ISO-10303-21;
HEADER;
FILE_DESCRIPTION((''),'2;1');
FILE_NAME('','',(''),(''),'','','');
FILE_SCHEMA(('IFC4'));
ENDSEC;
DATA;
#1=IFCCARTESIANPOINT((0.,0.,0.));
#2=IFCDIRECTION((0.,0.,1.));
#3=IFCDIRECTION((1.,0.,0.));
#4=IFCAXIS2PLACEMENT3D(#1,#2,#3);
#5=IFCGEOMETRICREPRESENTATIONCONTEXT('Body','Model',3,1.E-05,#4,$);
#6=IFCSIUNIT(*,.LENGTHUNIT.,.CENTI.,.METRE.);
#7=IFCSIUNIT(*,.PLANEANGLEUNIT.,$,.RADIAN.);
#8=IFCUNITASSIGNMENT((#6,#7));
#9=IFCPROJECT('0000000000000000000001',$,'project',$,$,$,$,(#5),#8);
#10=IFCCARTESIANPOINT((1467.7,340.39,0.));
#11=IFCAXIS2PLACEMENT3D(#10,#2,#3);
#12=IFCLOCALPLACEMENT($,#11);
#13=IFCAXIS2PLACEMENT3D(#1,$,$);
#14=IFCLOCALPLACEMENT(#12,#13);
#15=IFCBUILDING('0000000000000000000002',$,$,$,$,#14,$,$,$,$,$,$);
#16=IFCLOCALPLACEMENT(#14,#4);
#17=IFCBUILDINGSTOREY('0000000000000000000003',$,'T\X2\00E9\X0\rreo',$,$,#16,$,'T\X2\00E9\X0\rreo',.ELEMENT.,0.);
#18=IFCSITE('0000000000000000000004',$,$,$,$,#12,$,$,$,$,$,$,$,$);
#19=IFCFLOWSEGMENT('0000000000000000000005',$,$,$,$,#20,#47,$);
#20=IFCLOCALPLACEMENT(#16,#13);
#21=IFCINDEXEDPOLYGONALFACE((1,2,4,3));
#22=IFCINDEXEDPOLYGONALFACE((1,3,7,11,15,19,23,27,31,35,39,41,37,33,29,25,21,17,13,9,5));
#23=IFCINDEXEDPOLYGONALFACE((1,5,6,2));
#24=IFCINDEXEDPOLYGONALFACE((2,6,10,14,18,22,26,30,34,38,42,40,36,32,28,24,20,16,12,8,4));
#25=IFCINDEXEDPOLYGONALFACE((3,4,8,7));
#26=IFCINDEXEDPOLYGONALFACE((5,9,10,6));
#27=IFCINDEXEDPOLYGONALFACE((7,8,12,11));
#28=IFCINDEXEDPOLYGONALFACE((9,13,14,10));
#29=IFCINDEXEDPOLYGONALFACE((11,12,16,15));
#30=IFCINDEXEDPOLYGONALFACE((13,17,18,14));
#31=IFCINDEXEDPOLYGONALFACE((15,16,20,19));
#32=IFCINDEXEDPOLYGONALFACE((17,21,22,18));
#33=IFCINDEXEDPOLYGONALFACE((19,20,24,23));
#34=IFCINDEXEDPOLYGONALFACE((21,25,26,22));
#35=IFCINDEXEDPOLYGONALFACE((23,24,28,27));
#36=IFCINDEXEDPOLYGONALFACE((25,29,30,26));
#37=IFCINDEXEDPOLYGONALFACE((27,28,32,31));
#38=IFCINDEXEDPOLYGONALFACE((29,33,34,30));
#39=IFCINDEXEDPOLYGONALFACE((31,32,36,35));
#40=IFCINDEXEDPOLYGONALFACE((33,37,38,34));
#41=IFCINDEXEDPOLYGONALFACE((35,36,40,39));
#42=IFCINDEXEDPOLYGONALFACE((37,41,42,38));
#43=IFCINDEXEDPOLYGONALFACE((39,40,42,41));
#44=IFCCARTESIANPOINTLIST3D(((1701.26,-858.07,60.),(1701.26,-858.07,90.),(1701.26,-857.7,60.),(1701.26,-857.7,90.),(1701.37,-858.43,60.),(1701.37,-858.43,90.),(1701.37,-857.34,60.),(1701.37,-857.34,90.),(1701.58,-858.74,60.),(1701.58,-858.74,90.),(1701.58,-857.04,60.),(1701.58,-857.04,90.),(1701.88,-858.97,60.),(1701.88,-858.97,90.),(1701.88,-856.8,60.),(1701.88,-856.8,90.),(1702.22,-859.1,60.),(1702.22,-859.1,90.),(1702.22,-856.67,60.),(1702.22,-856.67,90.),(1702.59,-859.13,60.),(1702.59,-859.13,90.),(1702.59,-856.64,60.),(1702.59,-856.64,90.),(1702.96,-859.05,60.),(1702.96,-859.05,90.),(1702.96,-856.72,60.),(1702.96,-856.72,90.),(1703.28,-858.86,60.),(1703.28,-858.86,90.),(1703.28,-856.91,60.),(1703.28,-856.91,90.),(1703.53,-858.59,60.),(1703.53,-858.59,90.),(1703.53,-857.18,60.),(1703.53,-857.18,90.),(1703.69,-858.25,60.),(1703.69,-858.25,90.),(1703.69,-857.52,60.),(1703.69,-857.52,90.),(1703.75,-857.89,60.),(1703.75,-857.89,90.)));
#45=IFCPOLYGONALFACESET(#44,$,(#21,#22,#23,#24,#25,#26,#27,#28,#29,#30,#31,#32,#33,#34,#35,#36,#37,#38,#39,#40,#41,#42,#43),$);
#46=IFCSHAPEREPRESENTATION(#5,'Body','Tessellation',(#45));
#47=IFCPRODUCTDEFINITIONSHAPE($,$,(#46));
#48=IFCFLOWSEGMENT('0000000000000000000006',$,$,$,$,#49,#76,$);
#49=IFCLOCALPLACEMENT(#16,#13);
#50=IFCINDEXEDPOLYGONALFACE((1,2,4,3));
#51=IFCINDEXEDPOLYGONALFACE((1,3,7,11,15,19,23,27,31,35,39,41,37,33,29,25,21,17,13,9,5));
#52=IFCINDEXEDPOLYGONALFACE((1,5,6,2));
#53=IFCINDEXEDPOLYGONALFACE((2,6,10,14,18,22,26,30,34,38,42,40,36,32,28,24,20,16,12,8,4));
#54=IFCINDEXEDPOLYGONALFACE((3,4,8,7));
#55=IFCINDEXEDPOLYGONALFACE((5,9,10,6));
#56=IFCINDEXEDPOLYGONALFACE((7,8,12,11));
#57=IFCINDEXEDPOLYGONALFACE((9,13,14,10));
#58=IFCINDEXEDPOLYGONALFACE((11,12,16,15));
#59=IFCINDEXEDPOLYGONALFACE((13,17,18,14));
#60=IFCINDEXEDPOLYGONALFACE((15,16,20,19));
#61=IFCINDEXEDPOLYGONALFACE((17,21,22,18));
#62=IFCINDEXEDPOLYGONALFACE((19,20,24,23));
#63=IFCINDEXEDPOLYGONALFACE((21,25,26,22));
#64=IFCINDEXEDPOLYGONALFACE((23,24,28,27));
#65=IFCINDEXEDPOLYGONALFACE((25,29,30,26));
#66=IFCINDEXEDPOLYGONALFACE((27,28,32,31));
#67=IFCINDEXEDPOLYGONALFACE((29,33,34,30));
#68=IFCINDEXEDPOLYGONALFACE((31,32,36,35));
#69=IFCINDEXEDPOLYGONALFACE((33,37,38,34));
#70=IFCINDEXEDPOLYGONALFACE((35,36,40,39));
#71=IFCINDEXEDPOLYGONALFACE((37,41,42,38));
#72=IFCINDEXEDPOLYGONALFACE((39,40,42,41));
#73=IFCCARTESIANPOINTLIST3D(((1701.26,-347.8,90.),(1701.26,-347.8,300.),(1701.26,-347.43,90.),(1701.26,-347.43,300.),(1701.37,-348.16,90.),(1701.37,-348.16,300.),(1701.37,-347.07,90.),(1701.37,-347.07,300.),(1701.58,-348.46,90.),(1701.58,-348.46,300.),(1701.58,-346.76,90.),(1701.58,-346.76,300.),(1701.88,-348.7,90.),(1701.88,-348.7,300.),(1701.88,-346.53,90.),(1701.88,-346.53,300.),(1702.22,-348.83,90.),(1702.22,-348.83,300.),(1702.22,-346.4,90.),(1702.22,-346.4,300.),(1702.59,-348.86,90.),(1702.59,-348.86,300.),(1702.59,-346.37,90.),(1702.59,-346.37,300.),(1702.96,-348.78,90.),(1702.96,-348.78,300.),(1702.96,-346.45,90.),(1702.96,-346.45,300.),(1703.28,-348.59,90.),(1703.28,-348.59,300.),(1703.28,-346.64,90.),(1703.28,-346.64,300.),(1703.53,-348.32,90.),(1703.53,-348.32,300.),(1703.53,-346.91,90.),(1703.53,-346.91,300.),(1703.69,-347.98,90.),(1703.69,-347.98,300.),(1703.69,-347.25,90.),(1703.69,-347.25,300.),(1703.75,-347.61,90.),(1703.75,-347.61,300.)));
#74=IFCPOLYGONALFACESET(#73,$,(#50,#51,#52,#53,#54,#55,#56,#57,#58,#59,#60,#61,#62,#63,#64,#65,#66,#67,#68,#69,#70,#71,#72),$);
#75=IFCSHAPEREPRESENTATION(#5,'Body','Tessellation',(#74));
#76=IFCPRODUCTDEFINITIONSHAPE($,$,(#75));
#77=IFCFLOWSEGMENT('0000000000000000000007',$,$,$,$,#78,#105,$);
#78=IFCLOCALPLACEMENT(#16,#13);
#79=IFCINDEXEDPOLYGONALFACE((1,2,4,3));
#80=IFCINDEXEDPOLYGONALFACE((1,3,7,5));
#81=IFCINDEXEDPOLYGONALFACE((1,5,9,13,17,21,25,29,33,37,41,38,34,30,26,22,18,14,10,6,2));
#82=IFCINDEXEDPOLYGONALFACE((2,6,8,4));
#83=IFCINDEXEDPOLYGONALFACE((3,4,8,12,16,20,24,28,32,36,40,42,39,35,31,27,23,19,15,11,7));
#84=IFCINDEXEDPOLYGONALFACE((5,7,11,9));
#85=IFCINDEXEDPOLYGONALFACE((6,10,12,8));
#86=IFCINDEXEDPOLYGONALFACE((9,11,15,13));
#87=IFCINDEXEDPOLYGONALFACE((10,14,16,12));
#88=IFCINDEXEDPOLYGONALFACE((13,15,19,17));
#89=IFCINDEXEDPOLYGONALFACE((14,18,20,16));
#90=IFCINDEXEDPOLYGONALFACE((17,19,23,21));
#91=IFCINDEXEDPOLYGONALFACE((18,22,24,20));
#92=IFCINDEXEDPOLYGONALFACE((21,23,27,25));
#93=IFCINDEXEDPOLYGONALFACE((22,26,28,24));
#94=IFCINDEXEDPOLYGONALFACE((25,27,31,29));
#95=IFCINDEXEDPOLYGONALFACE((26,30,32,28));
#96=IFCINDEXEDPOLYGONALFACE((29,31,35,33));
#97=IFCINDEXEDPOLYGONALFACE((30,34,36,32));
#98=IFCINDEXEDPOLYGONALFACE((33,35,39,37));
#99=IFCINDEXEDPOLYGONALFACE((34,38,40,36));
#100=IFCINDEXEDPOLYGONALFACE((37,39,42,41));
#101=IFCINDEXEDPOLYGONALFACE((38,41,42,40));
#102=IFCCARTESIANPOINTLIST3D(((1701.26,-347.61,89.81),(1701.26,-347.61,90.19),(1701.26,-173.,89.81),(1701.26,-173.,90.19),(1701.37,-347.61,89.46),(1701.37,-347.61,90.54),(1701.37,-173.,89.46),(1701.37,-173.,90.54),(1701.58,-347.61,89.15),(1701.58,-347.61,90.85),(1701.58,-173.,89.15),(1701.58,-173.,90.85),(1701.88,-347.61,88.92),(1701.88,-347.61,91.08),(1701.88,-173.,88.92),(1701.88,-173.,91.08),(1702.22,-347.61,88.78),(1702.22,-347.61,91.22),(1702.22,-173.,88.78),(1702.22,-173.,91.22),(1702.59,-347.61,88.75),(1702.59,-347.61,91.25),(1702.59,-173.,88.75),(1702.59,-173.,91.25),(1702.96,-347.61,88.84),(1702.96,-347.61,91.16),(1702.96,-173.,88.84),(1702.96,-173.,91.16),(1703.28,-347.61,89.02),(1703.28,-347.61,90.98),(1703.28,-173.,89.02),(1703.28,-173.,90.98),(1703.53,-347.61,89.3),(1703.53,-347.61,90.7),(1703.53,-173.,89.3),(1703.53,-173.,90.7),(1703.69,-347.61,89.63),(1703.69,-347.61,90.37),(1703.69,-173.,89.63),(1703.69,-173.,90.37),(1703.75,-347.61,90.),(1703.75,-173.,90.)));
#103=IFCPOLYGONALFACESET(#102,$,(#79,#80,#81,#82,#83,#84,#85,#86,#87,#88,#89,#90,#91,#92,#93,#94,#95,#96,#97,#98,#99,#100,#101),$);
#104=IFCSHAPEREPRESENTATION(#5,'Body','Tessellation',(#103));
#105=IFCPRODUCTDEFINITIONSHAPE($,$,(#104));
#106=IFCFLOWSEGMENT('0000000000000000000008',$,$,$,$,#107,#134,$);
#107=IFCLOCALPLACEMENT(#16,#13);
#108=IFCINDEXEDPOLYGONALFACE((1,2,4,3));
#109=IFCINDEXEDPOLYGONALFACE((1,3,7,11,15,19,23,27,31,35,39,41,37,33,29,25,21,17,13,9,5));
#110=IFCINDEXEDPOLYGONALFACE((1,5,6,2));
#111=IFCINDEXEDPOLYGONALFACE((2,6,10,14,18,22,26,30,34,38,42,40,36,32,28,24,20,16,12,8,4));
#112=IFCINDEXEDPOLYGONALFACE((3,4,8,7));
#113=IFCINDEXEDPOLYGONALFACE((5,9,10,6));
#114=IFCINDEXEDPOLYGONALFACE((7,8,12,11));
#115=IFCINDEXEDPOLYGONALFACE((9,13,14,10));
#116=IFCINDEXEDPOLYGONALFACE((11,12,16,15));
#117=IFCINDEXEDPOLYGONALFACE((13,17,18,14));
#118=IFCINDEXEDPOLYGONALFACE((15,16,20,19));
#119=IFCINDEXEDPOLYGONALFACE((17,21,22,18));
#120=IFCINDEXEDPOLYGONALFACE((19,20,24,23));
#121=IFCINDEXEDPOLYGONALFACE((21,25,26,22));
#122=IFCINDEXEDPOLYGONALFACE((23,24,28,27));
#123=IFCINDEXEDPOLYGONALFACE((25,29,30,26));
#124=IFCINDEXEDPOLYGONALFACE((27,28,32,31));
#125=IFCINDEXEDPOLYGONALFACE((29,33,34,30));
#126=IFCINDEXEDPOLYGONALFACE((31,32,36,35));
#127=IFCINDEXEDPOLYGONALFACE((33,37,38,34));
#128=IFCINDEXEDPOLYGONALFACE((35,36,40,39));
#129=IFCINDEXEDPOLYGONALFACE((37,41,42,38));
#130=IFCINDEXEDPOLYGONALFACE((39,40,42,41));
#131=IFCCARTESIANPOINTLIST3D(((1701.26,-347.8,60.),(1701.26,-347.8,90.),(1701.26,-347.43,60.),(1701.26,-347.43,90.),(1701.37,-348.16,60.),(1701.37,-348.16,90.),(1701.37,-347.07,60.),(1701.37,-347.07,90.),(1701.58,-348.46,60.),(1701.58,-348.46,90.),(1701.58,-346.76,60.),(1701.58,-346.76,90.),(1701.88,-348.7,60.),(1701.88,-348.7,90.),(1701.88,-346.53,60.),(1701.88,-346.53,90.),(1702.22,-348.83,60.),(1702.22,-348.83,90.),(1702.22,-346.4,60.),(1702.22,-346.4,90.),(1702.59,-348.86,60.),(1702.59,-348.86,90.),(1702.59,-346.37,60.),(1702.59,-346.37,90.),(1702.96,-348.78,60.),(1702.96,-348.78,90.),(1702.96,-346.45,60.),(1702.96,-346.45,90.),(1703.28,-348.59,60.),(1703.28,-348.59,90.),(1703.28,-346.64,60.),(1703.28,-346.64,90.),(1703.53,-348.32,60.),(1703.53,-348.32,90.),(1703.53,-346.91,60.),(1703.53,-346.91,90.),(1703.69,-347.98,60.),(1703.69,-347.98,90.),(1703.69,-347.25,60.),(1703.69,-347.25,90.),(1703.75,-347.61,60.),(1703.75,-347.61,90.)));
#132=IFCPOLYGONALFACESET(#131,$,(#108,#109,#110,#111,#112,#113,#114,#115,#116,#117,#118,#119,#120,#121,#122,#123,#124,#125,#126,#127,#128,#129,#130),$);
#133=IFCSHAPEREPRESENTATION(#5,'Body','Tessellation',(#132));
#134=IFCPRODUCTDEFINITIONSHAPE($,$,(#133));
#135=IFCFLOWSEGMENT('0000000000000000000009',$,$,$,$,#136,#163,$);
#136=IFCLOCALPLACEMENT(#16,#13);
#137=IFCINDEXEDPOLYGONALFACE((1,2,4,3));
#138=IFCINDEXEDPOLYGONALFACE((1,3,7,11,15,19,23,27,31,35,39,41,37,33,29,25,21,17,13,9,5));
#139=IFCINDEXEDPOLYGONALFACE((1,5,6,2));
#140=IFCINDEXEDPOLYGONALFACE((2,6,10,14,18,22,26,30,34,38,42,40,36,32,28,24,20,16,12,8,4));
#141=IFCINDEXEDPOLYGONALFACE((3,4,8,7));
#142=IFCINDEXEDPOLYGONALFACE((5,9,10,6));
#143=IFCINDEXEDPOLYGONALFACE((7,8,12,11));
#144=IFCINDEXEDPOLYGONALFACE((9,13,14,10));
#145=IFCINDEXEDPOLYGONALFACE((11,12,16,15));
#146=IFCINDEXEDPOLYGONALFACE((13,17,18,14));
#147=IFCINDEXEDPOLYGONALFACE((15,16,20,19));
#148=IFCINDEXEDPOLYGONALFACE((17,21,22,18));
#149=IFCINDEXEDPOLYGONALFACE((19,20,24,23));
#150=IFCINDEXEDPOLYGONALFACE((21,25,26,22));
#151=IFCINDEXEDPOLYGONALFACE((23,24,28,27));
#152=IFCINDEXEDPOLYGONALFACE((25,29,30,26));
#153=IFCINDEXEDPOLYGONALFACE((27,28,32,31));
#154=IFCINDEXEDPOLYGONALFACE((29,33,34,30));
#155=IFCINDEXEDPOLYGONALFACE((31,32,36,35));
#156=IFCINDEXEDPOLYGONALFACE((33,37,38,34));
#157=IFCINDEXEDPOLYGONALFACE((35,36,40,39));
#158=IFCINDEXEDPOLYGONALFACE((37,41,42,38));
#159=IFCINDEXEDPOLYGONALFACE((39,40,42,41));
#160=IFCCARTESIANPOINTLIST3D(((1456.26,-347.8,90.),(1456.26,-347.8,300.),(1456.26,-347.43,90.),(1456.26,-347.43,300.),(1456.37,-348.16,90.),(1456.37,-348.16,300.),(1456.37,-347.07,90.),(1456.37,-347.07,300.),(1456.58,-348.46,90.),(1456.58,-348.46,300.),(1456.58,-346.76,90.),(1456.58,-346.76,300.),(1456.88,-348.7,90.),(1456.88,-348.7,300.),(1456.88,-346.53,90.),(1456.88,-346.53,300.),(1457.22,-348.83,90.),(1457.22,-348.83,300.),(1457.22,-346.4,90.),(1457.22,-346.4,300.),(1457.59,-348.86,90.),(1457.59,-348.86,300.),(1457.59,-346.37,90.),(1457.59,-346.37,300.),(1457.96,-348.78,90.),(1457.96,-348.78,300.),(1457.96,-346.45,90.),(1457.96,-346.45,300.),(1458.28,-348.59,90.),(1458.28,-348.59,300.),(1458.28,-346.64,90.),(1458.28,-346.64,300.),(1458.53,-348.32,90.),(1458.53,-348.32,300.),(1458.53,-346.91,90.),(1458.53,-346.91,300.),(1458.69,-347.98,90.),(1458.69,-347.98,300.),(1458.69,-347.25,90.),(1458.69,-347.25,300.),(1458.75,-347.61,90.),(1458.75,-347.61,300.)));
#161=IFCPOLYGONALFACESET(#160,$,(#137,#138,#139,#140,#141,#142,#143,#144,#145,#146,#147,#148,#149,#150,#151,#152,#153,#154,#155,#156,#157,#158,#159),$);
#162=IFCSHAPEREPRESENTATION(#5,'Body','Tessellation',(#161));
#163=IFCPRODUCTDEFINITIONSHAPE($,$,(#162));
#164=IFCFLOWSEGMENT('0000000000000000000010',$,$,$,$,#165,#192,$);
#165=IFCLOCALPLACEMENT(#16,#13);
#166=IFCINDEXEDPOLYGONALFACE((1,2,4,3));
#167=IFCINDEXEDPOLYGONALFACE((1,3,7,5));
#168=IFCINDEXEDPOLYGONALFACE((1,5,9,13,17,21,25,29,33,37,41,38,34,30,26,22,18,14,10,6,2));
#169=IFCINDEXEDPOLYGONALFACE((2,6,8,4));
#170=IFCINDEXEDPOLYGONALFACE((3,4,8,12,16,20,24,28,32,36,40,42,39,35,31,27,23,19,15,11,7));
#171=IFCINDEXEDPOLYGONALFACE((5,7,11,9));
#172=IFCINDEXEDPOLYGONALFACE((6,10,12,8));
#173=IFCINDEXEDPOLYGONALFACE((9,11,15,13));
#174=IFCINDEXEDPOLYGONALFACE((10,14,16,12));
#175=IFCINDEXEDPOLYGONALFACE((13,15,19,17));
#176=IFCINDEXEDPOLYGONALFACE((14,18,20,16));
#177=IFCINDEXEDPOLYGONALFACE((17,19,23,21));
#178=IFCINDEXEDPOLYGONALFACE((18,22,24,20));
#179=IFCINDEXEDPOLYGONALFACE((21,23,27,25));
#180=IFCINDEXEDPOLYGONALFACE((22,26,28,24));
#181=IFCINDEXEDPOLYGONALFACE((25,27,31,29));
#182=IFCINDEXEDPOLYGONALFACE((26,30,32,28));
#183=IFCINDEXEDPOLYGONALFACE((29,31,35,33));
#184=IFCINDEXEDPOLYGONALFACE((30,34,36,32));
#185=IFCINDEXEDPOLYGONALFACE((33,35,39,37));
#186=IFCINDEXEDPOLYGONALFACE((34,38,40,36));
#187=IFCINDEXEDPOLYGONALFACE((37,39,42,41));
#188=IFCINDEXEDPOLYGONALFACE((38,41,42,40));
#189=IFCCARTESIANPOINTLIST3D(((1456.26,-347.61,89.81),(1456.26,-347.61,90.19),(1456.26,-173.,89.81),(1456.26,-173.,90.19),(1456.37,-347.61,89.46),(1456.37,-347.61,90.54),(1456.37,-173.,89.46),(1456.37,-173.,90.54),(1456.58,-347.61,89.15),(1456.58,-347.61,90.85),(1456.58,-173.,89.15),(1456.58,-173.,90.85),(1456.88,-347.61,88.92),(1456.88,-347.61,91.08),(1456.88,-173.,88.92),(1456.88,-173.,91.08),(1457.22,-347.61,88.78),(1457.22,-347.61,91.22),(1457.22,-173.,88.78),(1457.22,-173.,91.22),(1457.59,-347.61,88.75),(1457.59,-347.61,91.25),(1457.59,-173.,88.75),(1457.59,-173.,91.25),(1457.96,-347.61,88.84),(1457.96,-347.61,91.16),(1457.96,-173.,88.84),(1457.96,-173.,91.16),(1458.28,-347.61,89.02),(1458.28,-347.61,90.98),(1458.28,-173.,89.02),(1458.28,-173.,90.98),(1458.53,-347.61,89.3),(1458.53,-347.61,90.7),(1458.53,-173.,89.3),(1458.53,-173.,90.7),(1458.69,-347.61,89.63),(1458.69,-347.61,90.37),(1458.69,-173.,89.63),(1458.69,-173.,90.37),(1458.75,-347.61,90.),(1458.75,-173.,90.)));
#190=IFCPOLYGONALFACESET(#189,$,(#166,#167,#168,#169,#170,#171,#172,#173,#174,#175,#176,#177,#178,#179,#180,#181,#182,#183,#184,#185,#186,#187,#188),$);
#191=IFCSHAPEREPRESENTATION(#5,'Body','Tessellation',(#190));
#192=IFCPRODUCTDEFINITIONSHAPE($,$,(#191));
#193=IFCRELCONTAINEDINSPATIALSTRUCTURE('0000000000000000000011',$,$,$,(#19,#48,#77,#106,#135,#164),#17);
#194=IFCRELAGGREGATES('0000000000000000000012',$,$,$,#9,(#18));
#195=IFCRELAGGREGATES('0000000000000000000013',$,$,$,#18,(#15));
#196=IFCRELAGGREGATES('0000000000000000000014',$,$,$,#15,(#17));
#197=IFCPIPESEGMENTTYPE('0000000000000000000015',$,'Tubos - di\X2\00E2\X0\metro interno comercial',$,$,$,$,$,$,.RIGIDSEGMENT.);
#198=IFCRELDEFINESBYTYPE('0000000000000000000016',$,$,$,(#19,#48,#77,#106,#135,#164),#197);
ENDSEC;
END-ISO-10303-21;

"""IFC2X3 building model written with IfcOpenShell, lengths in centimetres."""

from ifc_helpers import new_model, si_unit, frame, origin, origin_with_axes, origin_2d_with_axis, place, context, project, spatial, circle, extrude, type_object, element, save


model = new_model("IFC2X3")

# Units and contexts
model_context = context("Model", 3, precision=1e-05, world=origin_with_axes(), identifier="Body")
ifc_project = project(units=[si_unit("LENGTHUNIT", "METRE", prefix="CENTI"), si_unit("PLANEANGLEUNIT", "RADIAN")], contexts=[model_context])

# Site, building, storey
site_placement = place(None, frame((1467.7, 340.39, 0.0), z_axis=(0.0, 0.0, 1.0), x_axis=(1.0, 0.0, 0.0)))
site = spatial("IfcSite", under=ifc_project, at=site_placement)
building_placement = place(site_placement, origin())
building = spatial("IfcBuilding", under=site, at=building_placement)
storey_placement = place(building_placement, origin_with_axes())
storey = spatial("IfcBuildingStorey", under=building, at=storey_placement, Name="Térreo", LongName="Térreo", CompositionType="ELEMENT", Elevation=0.0)

# Flow segments
pipe_segment_type_1 = type_object("IfcPipeSegmentType", Name="Tubos - diâmetro interno comercial", PredefinedType="RIGIDSEGMENT")
flow_segment_1_placement = place(storey_placement, frame((1702.5, -857.89, 90.0), z_axis=(0.0, 0.0, 1.0), x_axis=(1.0, 0.0, 0.0)))
element("IfcFlowSegment", 1, at=flow_segment_1_placement, inside=storey, type_object=pipe_segment_type_1, context=model_context, shape_type="SolidModel", body=[
    extrude(circle(Radius=1.25, at=origin_2d_with_axis()), frame((0.0, 0.0, 0.0), z_axis=(0.0, 0.0, -1.0), x_axis=(1.0, 0.0, 0.0)), (0.0, 0.0, 1.0), 30.0),
])
flow_segment_2_placement = place(storey_placement, frame((1702.5, -347.61, 300.0), z_axis=(0.0, 0.0, 1.0), x_axis=(1.0, 0.0, 0.0)))
element("IfcFlowSegment", 2, at=flow_segment_2_placement, inside=storey, type_object=pipe_segment_type_1, context=model_context, shape_type="SolidModel", body=[
    extrude(circle(Radius=1.25, at=origin_2d_with_axis()), frame((0.0, 0.0, 0.0), z_axis=(0.0, 0.0, -1.0), x_axis=(1.0, 0.0, 0.0)), (0.0, 0.0, 1.0), 210.0),
])
flow_segment_3_placement = place(storey_placement, frame((1702.5, -260.31, 91.25), z_axis=(0.0, 0.0, 1.0), x_axis=(1.0, 0.0, 0.0)))
element("IfcFlowSegment", 3, at=flow_segment_3_placement, inside=storey, type_object=pipe_segment_type_1, context=model_context, shape_type="SolidModel", body=[
    extrude(circle(Radius=1.25, at=origin_2d_with_axis()), frame((0.0, -87.31, -1.25), z_axis=(0.0, 1.0, 0.0), x_axis=(1.0, 0.0, 0.0)), (0.0, 0.0, 1.0), 174.61),
])
flow_segment_4_placement = place(storey_placement, frame((1702.5, -347.61, 90.0), z_axis=(0.0, 0.0, 1.0), x_axis=(1.0, 0.0, 0.0)))
element("IfcFlowSegment", 4, at=flow_segment_4_placement, inside=storey, type_object=pipe_segment_type_1, context=model_context, shape_type="SolidModel", body=[
    extrude(circle(Radius=1.25, at=origin_2d_with_axis()), frame((0.0, 0.0, 0.0), z_axis=(0.0, 0.0, -1.0), x_axis=(1.0, 0.0, 0.0)), (0.0, 0.0, 1.0), 30.0),
])
flow_segment_5_placement = place(storey_placement, frame((1457.5, -347.61, 300.0), z_axis=(0.0, 0.0, 1.0), x_axis=(1.0, 0.0, 0.0)))
element("IfcFlowSegment", 5, at=flow_segment_5_placement, inside=storey, type_object=pipe_segment_type_1, context=model_context, shape_type="SolidModel", body=[
    extrude(circle(Radius=1.25, at=origin_2d_with_axis()), frame((0.0, 0.0, 0.0), z_axis=(0.0, 0.0, -1.0), x_axis=(1.0, 0.0, 0.0)), (0.0, 0.0, 1.0), 210.0),
])
flow_segment_6_placement = place(storey_placement, frame((1457.5, -260.31, 91.25), z_axis=(0.0, 0.0, 1.0), x_axis=(1.0, 0.0, 0.0)))
element("IfcFlowSegment", 6, at=flow_segment_6_placement, inside=storey, type_object=pipe_segment_type_1, context=model_context, shape_type="SolidModel", body=[
    extrude(circle(Radius=1.25, at=origin_2d_with_axis()), frame((0.0, -87.31, -1.25), z_axis=(0.0, 1.0, 0.0), x_axis=(1.0, 0.0, 0.0)), (0.0, 0.0, 1.0), 174.61),
])

save(model, "model.ifc")
